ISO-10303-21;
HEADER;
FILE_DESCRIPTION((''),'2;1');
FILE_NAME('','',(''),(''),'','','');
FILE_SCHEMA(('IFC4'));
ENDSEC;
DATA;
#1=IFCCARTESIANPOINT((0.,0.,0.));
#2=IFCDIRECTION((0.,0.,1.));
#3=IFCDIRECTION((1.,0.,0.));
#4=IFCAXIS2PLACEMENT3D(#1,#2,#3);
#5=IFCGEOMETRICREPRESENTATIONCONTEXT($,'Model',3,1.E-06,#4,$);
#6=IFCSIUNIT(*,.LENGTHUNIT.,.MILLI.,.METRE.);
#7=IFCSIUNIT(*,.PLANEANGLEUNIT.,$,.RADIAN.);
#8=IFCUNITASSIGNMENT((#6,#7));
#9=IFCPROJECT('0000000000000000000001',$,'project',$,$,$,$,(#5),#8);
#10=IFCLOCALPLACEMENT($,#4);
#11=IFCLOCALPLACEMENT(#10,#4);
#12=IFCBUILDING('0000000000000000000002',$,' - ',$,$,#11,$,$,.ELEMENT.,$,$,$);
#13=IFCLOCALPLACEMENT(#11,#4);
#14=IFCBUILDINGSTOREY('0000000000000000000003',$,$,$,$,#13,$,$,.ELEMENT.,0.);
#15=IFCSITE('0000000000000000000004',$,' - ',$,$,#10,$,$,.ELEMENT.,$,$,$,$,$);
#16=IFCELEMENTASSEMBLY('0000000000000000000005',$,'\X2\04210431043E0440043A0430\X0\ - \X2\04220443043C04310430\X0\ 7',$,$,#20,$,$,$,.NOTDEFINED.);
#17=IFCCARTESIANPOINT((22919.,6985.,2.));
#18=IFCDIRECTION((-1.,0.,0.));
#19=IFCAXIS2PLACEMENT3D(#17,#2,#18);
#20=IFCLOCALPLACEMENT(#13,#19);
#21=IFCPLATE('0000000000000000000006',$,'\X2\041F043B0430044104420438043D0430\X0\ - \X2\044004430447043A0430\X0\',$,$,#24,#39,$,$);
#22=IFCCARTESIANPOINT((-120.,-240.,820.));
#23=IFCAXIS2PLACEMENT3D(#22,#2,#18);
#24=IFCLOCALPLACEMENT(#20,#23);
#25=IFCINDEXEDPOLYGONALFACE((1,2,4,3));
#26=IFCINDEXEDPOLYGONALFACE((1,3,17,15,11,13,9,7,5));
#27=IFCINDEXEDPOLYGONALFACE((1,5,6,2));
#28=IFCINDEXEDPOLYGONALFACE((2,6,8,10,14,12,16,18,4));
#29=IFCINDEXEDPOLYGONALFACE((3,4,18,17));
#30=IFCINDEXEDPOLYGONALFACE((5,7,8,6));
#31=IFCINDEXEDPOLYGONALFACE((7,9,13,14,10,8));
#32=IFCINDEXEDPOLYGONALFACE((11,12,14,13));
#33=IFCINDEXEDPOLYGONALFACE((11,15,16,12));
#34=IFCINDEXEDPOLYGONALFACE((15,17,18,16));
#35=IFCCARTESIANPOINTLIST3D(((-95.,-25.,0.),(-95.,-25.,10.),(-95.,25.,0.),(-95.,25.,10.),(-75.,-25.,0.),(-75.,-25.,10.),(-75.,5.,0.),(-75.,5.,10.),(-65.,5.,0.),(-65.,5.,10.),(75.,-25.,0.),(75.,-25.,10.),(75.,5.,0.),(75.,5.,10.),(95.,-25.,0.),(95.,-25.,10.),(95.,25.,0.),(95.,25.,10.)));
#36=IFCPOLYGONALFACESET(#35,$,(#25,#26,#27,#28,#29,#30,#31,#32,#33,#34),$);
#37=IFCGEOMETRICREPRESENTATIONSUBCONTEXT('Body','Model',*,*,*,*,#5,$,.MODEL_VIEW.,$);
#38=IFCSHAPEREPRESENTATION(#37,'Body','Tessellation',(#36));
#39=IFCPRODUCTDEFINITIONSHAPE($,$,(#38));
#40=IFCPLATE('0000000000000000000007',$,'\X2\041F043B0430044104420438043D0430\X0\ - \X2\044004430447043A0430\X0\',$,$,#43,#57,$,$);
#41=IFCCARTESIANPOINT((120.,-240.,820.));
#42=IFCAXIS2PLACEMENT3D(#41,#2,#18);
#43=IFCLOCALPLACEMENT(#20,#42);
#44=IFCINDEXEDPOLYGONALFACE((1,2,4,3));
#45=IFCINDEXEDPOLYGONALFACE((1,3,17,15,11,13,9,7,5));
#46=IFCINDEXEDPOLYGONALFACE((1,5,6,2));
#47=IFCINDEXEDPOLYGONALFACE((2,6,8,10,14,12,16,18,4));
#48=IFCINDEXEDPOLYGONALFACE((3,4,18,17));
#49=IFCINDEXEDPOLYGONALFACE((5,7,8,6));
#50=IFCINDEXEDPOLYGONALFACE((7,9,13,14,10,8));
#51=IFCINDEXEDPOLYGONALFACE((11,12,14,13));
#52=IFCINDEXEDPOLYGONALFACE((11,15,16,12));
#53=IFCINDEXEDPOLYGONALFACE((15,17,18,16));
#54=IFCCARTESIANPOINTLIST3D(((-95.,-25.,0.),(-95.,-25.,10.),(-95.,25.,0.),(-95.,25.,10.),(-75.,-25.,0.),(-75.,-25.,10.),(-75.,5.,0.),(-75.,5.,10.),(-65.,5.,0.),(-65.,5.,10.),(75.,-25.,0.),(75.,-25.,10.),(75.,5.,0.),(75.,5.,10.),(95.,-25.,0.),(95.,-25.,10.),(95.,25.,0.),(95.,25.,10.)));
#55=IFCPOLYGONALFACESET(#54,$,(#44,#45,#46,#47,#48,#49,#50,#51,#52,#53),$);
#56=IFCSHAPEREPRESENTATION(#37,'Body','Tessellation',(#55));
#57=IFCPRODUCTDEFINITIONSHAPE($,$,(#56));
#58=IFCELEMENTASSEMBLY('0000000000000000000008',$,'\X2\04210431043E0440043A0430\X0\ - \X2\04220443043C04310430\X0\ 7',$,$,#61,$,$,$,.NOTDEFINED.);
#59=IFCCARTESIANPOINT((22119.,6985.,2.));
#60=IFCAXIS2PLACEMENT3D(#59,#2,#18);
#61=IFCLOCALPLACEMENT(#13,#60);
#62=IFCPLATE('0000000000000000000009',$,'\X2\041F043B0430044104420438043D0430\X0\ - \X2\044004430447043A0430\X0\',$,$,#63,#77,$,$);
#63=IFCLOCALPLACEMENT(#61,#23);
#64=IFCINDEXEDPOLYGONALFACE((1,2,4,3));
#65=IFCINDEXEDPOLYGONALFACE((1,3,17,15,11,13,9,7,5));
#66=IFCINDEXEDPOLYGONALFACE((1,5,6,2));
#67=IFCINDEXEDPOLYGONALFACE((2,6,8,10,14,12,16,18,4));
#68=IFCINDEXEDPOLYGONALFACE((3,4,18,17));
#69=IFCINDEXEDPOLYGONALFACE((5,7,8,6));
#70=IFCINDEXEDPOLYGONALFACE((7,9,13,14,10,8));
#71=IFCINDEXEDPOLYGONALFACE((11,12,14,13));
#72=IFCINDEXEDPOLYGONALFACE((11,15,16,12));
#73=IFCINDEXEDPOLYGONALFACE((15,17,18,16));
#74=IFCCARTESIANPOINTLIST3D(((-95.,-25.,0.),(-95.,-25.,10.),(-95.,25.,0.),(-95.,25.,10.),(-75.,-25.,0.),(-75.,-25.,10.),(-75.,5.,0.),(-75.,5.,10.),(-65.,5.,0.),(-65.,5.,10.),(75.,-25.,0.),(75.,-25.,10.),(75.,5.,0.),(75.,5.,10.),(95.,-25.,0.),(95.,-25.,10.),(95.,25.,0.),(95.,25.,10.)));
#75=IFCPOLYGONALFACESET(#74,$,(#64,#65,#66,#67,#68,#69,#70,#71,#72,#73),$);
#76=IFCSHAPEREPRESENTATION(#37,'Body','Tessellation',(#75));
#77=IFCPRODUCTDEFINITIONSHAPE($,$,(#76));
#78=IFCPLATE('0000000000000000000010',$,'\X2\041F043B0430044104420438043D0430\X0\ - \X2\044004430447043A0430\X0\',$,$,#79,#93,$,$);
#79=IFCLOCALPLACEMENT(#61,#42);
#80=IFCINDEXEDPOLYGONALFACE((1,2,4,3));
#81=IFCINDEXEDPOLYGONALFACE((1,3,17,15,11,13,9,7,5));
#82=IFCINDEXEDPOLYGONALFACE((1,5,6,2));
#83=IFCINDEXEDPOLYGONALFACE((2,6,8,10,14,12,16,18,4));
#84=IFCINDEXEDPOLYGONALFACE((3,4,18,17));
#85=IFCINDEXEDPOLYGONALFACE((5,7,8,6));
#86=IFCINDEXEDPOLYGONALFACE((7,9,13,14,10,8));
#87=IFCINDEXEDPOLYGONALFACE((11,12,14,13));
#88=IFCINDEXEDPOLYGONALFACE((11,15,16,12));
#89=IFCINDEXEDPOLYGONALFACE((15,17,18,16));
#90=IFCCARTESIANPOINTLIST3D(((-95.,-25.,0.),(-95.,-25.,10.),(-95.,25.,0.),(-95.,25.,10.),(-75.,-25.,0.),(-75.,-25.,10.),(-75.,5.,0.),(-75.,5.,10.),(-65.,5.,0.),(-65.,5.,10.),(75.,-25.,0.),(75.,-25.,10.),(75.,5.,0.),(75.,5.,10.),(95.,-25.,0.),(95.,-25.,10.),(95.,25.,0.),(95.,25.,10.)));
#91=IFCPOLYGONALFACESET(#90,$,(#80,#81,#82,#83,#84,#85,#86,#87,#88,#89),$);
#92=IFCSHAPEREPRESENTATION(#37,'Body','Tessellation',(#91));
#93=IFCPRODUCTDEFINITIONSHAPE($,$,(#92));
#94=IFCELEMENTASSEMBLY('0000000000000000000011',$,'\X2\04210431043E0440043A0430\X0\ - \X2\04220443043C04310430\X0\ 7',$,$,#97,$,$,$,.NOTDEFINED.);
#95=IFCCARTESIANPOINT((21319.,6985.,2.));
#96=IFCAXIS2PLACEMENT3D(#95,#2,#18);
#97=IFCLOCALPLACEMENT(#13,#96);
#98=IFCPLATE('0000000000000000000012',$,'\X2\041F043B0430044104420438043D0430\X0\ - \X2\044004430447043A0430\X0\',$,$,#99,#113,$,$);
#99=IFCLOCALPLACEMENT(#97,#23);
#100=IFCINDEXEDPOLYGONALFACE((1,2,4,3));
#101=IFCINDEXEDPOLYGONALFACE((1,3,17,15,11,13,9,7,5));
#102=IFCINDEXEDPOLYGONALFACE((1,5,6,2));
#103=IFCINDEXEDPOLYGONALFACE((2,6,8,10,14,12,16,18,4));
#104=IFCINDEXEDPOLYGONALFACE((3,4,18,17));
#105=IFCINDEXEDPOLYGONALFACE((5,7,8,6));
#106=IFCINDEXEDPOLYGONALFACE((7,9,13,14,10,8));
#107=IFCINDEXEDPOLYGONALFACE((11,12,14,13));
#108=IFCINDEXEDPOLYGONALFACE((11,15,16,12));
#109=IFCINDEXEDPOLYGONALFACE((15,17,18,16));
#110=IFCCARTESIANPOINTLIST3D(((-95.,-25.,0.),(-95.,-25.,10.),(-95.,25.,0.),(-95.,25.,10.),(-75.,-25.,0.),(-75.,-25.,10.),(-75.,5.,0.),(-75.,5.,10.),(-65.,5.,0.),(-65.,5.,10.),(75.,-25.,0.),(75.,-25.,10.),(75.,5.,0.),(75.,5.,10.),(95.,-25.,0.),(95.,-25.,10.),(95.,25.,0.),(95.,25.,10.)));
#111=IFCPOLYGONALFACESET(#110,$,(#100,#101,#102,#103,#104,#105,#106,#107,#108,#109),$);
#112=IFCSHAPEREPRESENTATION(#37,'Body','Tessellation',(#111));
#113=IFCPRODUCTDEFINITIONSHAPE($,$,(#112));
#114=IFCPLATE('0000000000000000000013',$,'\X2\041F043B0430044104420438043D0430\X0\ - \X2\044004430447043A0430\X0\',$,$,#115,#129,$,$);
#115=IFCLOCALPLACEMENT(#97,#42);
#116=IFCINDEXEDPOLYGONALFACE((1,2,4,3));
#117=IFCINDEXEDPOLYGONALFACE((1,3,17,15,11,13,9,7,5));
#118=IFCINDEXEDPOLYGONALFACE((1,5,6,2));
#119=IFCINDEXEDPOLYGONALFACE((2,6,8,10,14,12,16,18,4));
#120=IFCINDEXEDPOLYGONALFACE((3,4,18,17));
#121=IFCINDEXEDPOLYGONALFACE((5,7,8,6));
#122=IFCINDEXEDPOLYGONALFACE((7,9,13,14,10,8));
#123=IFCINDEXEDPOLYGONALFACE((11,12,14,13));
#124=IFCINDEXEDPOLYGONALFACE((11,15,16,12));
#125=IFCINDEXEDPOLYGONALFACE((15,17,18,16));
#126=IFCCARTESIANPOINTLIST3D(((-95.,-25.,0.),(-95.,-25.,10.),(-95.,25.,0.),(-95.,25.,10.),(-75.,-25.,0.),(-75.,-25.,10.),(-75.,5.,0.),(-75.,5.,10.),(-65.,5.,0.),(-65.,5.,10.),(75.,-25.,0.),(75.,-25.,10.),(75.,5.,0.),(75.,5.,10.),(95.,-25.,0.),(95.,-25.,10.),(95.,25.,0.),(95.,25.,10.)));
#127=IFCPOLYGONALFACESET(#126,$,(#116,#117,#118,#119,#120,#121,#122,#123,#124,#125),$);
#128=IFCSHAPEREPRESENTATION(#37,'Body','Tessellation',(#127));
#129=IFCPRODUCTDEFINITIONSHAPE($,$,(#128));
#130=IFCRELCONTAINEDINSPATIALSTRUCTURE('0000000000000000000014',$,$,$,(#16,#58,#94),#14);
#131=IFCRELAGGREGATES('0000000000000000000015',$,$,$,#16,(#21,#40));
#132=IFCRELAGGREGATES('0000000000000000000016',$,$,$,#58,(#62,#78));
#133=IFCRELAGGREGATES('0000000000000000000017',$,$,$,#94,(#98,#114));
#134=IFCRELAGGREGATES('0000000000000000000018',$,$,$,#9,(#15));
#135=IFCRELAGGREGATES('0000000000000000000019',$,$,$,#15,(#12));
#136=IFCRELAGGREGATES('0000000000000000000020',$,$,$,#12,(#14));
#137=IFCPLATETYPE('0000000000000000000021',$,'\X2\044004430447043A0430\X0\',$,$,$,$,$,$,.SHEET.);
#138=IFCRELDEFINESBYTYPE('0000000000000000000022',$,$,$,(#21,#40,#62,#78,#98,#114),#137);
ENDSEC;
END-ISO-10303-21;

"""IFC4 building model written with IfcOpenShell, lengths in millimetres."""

from ifc_helpers import new_model, si_unit, frame, origin_with_axes, place, context, subcontext, project, spatial, line, indexed_curve, outline, extrude, source, transform, mapped, type_object, element, aggregate, save


model = new_model("IFC4")

# Units and contexts
model_context = context("Model", 3, precision=1e-06, world=origin_with_axes())
body_context = subcontext(model_context, "Body", "Model", "MODEL_VIEW")
ifc_project = project(units=[si_unit("LENGTHUNIT", "METRE", prefix="MILLI"), si_unit("PLANEANGLEUNIT", "RADIAN")], contexts=[model_context])

# Site, building, storey
site_placement = place(None, origin_with_axes())
site = spatial("IfcSite", under=ifc_project, at=site_placement, Name=" - ", CompositionType="ELEMENT")
building_placement = place(site_placement, origin_with_axes())
building = spatial("IfcBuilding", under=site, at=building_placement, Name=" - ", CompositionType="ELEMENT")
storey_placement = place(building_placement, origin_with_axes())
storey = spatial("IfcBuildingStorey", under=building, at=storey_placement, CompositionType="ELEMENT", Elevation=0.0)

# Element assemblies, plates
assembly_1_placement = place(storey_placement, frame((22919.0, 6985.0, 2.0), z_axis=(0.0, 0.0, 1.0), x_axis=(-1.0, 0.0, 0.0)))
assembly_1 = element("IfcElementAssembly", 1, at=assembly_1_placement, inside=storey, Name="Сборка - Тумба 7", PredefinedType="NOTDEFINED")
plate_type_1 = type_object("IfcPlateType", Name="ручка", PredefinedType="SHEET")
shared_shape_1 = source(origin_with_axes(), body_context, "Body", "SweptSolid", [
    extrude(outline(indexed_curve([(-95.0, -25.0), (-75.0, -25.0), (-75.0, 5.0), (-65.0, 5.0), (75.0, 5.0), (75.0, -25.0), (95.0, -25.0), (95.0, 25.0), (-95.0, 25.0)], segments=[line(1, 2), line(2, 3), line(3, 4), line(4, 5), line(5, 6), line(6, 7), line(7, 8), line(8, 9), line(9, 1)])), origin_with_axes(), (0.0, 0.0, 1.0), 10.0),
])
plate_1_placement = place(assembly_1_placement, frame((-120.0, -240.0, 820.0), z_axis=(0.0, 0.0, 1.0), x_axis=(-1.0, 0.0, 0.0)))
plate_1 = element("IfcPlate", 2, at=plate_1_placement, type_object=plate_type_1, Name="Пластина - ручка", context=body_context, shape_type="MappedRepresentation", body=[
    mapped(shared_shape_1, transform((0.0, 0.0, 0.0), x_axis=(1.0, 0.0, 0.0), y_axis=(0.0, 1.0, 0.0), z_axis=(0.0, 0.0, 1.0), scale=1.0)),
])
plate_2_placement = place(assembly_1_placement, frame((120.0, -240.0, 820.0), z_axis=(0.0, 0.0, 1.0), x_axis=(-1.0, 0.0, 0.0)))
plate_2 = element("IfcPlate", 3, at=plate_2_placement, type_object=plate_type_1, Name="Пластина - ручка", context=body_context, shape_type="MappedRepresentation", body=[
    mapped(shared_shape_1, transform((0.0, 0.0, 0.0), x_axis=(1.0, 0.0, 0.0), y_axis=(0.0, 1.0, 0.0), z_axis=(0.0, 0.0, 1.0), scale=1.0)),
])
aggregate(assembly_1, [plate_1, plate_2])
assembly_2_placement = place(storey_placement, frame((22119.0, 6985.0, 2.0), z_axis=(0.0, 0.0, 1.0), x_axis=(-1.0, 0.0, 0.0)))
assembly_2 = element("IfcElementAssembly", 4, at=assembly_2_placement, inside=storey, Name="Сборка - Тумба 7", PredefinedType="NOTDEFINED")
plate_3_placement = place(assembly_2_placement, frame((-120.0, -240.0, 820.0), z_axis=(0.0, 0.0, 1.0), x_axis=(-1.0, 0.0, 0.0)))
plate_3 = element("IfcPlate", 5, at=plate_3_placement, type_object=plate_type_1, Name="Пластина - ручка", context=body_context, shape_type="MappedRepresentation", body=[
    mapped(shared_shape_1, transform((0.0, 0.0, 0.0), x_axis=(1.0, 0.0, 0.0), y_axis=(0.0, 1.0, 0.0), z_axis=(0.0, 0.0, 1.0), scale=1.0)),
])
plate_4_placement = place(assembly_2_placement, frame((120.0, -240.0, 820.0), z_axis=(0.0, 0.0, 1.0), x_axis=(-1.0, 0.0, 0.0)))
plate_4 = element("IfcPlate", 6, at=plate_4_placement, type_object=plate_type_1, Name="Пластина - ручка", context=body_context, shape_type="MappedRepresentation", body=[
    mapped(shared_shape_1, transform((0.0, 0.0, 0.0), x_axis=(1.0, 0.0, 0.0), y_axis=(0.0, 1.0, 0.0), z_axis=(0.0, 0.0, 1.0), scale=1.0)),
])
aggregate(assembly_2, [plate_3, plate_4])
assembly_3_placement = place(storey_placement, frame((21319.0, 6985.0, 2.0), z_axis=(0.0, 0.0, 1.0), x_axis=(-1.0, 0.0, 0.0)))
assembly_3 = element("IfcElementAssembly", 7, at=assembly_3_placement, inside=storey, Name="Сборка - Тумба 7", PredefinedType="NOTDEFINED")
plate_5_placement = place(assembly_3_placement, frame((-120.0, -240.0, 820.0), z_axis=(0.0, 0.0, 1.0), x_axis=(-1.0, 0.0, 0.0)))
plate_5 = element("IfcPlate", 8, at=plate_5_placement, type_object=plate_type_1, Name="Пластина - ручка", context=body_context, shape_type="MappedRepresentation", body=[
    mapped(shared_shape_1, transform((0.0, 0.0, 0.0), x_axis=(1.0, 0.0, 0.0), y_axis=(0.0, 1.0, 0.0), z_axis=(0.0, 0.0, 1.0), scale=1.0)),
])
plate_6_placement = place(assembly_3_placement, frame((120.0, -240.0, 820.0), z_axis=(0.0, 0.0, 1.0), x_axis=(-1.0, 0.0, 0.0)))
plate_6 = element("IfcPlate", 9, at=plate_6_placement, type_object=plate_type_1, Name="Пластина - ручка", context=body_context, shape_type="MappedRepresentation", body=[
    mapped(shared_shape_1, transform((0.0, 0.0, 0.0), x_axis=(1.0, 0.0, 0.0), y_axis=(0.0, 1.0, 0.0), z_axis=(0.0, 0.0, 1.0), scale=1.0)),
])
aggregate(assembly_3, [plate_5, plate_6])

save(model, "model.ifc")
